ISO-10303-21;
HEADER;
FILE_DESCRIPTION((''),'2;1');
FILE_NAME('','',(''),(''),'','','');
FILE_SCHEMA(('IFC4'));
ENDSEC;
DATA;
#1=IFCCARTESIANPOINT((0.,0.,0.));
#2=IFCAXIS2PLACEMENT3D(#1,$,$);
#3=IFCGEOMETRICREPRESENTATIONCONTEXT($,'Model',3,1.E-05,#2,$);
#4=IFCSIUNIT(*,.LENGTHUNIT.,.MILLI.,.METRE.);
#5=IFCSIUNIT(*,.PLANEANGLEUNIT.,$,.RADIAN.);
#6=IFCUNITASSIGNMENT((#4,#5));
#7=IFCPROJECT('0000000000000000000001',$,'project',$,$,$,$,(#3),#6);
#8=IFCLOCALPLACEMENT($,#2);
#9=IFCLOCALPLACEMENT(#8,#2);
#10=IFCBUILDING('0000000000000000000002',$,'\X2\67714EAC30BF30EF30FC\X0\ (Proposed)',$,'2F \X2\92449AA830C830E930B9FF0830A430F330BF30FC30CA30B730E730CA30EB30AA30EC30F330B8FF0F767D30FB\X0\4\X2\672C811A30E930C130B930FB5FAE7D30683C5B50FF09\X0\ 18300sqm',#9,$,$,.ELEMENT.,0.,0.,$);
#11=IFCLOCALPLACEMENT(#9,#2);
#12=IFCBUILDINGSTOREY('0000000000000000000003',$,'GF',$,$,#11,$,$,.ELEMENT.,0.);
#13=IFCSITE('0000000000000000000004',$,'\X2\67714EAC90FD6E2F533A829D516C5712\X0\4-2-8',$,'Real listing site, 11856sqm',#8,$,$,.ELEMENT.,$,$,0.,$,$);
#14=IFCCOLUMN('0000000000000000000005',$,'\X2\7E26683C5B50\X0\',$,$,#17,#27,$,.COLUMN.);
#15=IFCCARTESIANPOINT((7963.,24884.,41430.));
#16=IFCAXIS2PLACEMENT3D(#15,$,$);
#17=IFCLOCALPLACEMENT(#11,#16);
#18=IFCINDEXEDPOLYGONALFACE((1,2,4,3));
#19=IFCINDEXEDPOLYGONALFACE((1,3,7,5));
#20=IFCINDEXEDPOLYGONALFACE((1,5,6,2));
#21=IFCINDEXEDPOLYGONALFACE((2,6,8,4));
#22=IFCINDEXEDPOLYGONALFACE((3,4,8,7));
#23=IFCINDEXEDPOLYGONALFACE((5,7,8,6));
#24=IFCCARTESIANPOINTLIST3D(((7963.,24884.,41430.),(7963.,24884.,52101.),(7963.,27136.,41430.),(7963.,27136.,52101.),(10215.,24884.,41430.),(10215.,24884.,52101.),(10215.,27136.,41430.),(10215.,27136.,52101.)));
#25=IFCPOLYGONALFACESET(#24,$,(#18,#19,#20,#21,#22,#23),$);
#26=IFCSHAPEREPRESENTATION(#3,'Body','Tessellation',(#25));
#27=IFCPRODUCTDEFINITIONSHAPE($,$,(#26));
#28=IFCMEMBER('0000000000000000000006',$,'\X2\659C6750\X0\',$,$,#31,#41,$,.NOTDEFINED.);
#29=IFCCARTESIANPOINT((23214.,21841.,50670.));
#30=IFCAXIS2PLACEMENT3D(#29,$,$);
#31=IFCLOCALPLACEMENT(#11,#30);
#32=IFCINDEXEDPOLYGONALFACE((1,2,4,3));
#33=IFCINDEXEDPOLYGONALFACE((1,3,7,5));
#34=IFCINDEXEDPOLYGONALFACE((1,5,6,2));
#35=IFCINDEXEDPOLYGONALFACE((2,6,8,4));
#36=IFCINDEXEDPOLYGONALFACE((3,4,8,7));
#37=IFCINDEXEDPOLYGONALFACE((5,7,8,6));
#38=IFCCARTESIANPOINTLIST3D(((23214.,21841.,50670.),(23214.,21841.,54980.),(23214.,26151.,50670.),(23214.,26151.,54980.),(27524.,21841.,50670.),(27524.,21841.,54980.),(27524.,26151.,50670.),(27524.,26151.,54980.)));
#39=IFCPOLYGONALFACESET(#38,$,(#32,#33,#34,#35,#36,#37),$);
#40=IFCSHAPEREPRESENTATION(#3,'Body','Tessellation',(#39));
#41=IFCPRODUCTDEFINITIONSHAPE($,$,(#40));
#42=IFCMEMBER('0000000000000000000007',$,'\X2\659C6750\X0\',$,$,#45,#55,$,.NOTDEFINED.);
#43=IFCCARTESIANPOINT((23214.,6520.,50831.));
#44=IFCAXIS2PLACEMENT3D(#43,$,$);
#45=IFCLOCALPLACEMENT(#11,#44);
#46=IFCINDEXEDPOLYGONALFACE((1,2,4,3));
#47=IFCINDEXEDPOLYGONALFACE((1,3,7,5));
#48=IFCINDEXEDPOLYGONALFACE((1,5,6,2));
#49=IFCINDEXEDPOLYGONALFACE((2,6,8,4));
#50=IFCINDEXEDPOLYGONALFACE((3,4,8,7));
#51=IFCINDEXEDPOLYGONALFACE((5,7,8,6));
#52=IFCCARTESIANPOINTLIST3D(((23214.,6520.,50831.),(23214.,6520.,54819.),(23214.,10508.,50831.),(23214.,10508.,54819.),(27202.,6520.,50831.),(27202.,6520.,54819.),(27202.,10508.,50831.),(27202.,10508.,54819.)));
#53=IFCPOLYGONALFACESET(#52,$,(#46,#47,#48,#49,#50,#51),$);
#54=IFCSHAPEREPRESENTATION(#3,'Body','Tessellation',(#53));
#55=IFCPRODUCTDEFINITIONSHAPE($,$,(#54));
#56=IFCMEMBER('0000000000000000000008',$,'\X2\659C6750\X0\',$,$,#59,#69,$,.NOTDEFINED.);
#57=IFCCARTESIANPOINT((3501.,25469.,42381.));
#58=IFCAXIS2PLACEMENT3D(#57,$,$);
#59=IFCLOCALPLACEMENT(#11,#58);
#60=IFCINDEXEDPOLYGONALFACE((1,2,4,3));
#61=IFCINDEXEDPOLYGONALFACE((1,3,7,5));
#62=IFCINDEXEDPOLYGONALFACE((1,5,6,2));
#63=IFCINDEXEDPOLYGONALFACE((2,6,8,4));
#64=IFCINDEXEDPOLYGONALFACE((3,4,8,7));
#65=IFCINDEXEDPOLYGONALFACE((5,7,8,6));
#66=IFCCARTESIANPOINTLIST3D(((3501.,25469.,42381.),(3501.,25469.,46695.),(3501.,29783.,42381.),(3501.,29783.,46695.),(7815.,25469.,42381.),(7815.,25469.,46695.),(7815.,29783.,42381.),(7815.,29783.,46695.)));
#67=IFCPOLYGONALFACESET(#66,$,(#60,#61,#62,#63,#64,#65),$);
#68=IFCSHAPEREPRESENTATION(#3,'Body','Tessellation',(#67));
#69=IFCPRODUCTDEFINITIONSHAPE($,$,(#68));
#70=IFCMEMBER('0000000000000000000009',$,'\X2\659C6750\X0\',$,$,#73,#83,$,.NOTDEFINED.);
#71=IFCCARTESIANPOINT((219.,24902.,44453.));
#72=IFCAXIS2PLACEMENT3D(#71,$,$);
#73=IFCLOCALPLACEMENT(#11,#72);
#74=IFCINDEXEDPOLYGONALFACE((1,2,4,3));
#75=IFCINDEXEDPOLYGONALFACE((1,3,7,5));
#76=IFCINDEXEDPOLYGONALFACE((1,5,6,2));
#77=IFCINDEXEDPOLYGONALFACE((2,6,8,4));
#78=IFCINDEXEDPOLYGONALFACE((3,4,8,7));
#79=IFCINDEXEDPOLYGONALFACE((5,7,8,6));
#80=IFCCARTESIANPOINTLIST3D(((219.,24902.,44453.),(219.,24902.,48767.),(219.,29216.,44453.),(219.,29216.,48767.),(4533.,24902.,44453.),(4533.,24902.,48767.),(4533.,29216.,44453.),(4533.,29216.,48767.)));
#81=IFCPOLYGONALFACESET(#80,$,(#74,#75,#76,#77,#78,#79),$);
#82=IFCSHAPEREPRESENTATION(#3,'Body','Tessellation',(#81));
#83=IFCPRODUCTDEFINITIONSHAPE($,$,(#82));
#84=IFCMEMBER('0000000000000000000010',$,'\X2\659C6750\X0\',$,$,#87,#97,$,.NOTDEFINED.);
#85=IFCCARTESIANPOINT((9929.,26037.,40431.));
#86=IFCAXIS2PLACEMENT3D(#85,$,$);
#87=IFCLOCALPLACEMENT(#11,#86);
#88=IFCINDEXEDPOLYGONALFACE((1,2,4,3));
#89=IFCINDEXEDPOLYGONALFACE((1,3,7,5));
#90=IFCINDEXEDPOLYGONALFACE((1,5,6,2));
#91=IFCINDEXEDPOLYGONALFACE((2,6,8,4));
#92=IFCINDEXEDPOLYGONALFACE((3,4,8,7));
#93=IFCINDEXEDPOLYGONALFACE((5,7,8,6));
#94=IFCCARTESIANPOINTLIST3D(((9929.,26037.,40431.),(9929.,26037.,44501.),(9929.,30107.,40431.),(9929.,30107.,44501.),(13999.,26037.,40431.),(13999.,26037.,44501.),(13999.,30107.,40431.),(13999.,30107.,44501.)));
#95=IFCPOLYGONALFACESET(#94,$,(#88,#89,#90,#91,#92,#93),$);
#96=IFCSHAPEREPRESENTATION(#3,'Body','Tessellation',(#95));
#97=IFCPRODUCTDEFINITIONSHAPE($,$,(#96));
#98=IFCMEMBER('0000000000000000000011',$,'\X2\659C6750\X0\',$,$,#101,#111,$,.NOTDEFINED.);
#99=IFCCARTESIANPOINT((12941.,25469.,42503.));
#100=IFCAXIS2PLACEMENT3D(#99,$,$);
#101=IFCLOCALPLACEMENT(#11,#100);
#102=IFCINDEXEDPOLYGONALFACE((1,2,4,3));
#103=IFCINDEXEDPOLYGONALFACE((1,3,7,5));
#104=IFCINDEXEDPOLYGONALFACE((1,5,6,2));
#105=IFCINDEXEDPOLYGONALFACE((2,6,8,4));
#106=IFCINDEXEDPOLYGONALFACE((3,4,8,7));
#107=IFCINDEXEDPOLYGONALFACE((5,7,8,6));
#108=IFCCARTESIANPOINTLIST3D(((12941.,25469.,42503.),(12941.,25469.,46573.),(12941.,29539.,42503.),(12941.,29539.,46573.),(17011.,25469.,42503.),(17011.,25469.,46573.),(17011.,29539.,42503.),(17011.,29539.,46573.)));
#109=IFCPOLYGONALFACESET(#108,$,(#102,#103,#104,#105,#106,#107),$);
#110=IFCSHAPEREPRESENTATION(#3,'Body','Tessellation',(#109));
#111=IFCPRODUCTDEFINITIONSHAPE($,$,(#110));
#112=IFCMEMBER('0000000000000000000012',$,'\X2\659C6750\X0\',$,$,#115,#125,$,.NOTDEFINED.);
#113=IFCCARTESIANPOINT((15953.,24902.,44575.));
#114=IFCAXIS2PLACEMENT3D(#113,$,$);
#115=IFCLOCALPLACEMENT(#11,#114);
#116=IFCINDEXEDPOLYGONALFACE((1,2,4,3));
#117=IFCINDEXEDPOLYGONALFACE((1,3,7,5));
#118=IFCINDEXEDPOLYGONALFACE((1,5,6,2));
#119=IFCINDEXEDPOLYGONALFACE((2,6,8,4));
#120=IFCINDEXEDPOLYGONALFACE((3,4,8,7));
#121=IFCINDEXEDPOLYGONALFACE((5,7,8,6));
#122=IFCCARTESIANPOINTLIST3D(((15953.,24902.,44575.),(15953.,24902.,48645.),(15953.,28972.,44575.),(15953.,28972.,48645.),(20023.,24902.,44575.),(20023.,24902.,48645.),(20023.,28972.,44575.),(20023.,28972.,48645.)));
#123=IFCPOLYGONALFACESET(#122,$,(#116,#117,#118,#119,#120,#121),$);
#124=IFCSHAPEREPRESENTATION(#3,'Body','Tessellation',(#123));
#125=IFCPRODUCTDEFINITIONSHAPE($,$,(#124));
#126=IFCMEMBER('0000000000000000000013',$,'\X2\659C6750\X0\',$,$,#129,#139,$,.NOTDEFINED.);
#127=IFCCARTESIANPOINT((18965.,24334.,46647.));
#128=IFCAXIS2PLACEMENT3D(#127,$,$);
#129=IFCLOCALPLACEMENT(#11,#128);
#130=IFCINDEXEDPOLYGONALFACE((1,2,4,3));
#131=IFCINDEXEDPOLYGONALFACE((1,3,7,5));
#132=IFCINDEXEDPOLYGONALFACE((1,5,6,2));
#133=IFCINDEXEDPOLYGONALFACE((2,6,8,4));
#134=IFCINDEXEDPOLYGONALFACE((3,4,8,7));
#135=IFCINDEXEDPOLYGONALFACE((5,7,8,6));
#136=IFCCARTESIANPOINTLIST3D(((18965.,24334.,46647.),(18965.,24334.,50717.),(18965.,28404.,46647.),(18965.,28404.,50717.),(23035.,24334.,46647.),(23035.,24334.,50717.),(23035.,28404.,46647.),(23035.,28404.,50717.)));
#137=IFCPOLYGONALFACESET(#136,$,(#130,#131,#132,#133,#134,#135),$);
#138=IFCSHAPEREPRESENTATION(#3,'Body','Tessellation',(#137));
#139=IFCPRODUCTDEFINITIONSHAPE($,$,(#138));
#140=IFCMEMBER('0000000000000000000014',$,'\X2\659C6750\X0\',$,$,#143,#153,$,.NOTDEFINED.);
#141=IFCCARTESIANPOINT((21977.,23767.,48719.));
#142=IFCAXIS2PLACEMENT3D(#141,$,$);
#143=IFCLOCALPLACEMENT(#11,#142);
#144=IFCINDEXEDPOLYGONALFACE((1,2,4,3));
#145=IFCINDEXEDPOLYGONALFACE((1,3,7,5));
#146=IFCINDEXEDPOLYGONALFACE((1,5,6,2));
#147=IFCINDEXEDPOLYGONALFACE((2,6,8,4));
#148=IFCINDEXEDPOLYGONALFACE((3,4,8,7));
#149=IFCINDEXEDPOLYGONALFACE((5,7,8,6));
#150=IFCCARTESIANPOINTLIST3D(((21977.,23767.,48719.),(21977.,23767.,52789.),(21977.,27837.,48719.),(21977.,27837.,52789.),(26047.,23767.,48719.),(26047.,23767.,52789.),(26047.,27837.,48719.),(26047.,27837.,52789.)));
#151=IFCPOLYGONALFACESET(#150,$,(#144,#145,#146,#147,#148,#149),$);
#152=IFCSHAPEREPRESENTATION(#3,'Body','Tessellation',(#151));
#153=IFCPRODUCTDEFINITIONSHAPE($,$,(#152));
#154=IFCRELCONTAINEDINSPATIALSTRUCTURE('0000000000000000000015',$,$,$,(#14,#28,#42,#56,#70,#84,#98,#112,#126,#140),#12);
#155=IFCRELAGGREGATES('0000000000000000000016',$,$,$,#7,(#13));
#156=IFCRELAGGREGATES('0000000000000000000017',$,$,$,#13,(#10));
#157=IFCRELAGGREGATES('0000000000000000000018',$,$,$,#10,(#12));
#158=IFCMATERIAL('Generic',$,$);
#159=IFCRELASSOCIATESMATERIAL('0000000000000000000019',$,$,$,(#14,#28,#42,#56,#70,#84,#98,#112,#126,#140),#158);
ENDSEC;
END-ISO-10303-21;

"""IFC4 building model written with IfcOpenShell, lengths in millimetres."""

from ifc_helpers import new_model, si_unit, frame, frame_2d, origin, place, context, project, spatial, rectangle, extrude, material, element, save


model = new_model("IFC4")

# Units and contexts
model_context = context("Model", 3, precision=1e-05, world=origin())
ifc_project = project(units=[si_unit("LENGTHUNIT", "METRE", prefix="MILLI"), si_unit("PLANEANGLEUNIT", "RADIAN")], contexts=[model_context])

# Site, building, storey
site_placement = place(None, origin())
site = spatial("IfcSite", under=ifc_project, at=site_placement, Name="東京都港区芝公園4-2-8", ObjectType="Real listing site, 11856sqm", CompositionType="ELEMENT", RefElevation=0.0)
building_placement = place(site_placement, origin())
building = spatial("IfcBuilding", under=site, at=building_placement, Name="東京タワー (Proposed)", ObjectType="2F 鉄骨トラス（インターナショナルオレンジ／白・4本脚ラチス・微細格子） 18300sqm", CompositionType="ELEMENT", ElevationOfRefHeight=0.0, ElevationOfTerrain=0.0)
storey_placement = place(building_placement, origin())
storey = spatial("IfcBuildingStorey", under=building, at=storey_placement, Name="GF", CompositionType="ELEMENT", Elevation=0.0)

# Column
ifc_material = material(Name="Generic")
column_1_placement = place(storey_placement, frame((7963.0, 24884.0, 41430.0)))
element("IfcColumn", 1, at=column_1_placement, inside=storey, material=ifc_material, Name="縦格子", PredefinedType="COLUMN", context=model_context, shape_type="SweptSolid", body=[
    extrude(rectangle(XDim=2252.0, YDim=2252.0, at=frame_2d((1126.0, 1126.0))), frame((7963.0, 24884.0, 41430.0)), (0.0, 0.0, 1.0), 10671.0),
])

# Members
member_1_placement = place(storey_placement, frame((23214.0, 21841.0, 50670.0)))
element("IfcMember", 2, at=member_1_placement, inside=storey, material=ifc_material, Name="斜材", PredefinedType="NOTDEFINED", context=model_context, shape_type="SweptSolid", body=[
    extrude(rectangle(XDim=4310.0, YDim=4310.0, at=frame_2d((2155.0, 2155.0))), frame((23214.0, 21841.0, 50670.0)), (0.0, 0.0, 1.0), 4310.0),
])
member_2_placement = place(storey_placement, frame((23214.0, 6520.0, 50831.0)))
element("IfcMember", 3, at=member_2_placement, inside=storey, material=ifc_material, Name="斜材", PredefinedType="NOTDEFINED", context=model_context, shape_type="SweptSolid", body=[
    extrude(rectangle(XDim=3988.0, YDim=3988.0, at=frame_2d((1994.0, 1994.0))), frame((23214.0, 6520.0, 50831.0)), (0.0, 0.0, 1.0), 3988.0),
])
member_3_placement = place(storey_placement, frame((3501.0, 25469.0, 42381.0)))
element("IfcMember", 4, at=member_3_placement, inside=storey, material=ifc_material, Name="斜材", PredefinedType="NOTDEFINED", context=model_context, shape_type="SweptSolid", body=[
    extrude(rectangle(XDim=4314.0, YDim=4314.0, at=frame_2d((2157.0, 2157.0))), frame((3501.0, 25469.0, 42381.0)), (0.0, 0.0, 1.0), 4314.0),
])
member_4_placement = place(storey_placement, frame((219.0, 24902.0, 44453.0)))
element("IfcMember", 5, at=member_4_placement, inside=storey, material=ifc_material, Name="斜材", PredefinedType="NOTDEFINED", context=model_context, shape_type="SweptSolid", body=[
    extrude(rectangle(XDim=4314.0, YDim=4314.0, at=frame_2d((2157.0, 2157.0))), frame((219.0, 24902.0, 44453.0)), (0.0, 0.0, 1.0), 4314.0),
])
member_5_placement = place(storey_placement, frame((9929.0, 26037.0, 40431.0)))
element("IfcMember", 6, at=member_5_placement, inside=storey, material=ifc_material, Name="斜材", PredefinedType="NOTDEFINED", context=model_context, shape_type="SweptSolid", body=[
    extrude(rectangle(XDim=4070.0, YDim=4070.0, at=frame_2d((2035.0, 2035.0))), frame((9929.0, 26037.0, 40431.0)), (0.0, 0.0, 1.0), 4070.0),
])
member_6_placement = place(storey_placement, frame((12941.0, 25469.0, 42503.0)))
element("IfcMember", 7, at=member_6_placement, inside=storey, material=ifc_material, Name="斜材", PredefinedType="NOTDEFINED", context=model_context, shape_type="SweptSolid", body=[
    extrude(rectangle(XDim=4070.0, YDim=4070.0, at=frame_2d((2035.0, 2035.0))), frame((12941.0, 25469.0, 42503.0)), (0.0, 0.0, 1.0), 4070.0),
])
member_7_placement = place(storey_placement, frame((15953.0, 24902.0, 44575.0)))
element("IfcMember", 8, at=member_7_placement, inside=storey, material=ifc_material, Name="斜材", PredefinedType="NOTDEFINED", context=model_context, shape_type="SweptSolid", body=[
    extrude(rectangle(XDim=4070.0, YDim=4070.0, at=frame_2d((2035.0, 2035.0))), frame((15953.0, 24902.0, 44575.0)), (0.0, 0.0, 1.0), 4070.0),
])
member_8_placement = place(storey_placement, frame((18965.0, 24334.0, 46647.0)))
element("IfcMember", 9, at=member_8_placement, inside=storey, material=ifc_material, Name="斜材", PredefinedType="NOTDEFINED", context=model_context, shape_type="SweptSolid", body=[
    extrude(rectangle(XDim=4070.0, YDim=4070.0, at=frame_2d((2035.0, 2035.0))), frame((18965.0, 24334.0, 46647.0)), (0.0, 0.0, 1.0), 4070.0),
])
member_9_placement = place(storey_placement, frame((21977.0, 23767.0, 48719.0)))
element("IfcMember", 10, at=member_9_placement, inside=storey, material=ifc_material, Name="斜材", PredefinedType="NOTDEFINED", context=model_context, shape_type="SweptSolid", body=[
    extrude(rectangle(XDim=4070.0, YDim=4070.0, at=frame_2d((2035.0, 2035.0))), frame((21977.0, 23767.0, 48719.0)), (0.0, 0.0, 1.0), 4070.0),
])

save(model, "model.ifc")
